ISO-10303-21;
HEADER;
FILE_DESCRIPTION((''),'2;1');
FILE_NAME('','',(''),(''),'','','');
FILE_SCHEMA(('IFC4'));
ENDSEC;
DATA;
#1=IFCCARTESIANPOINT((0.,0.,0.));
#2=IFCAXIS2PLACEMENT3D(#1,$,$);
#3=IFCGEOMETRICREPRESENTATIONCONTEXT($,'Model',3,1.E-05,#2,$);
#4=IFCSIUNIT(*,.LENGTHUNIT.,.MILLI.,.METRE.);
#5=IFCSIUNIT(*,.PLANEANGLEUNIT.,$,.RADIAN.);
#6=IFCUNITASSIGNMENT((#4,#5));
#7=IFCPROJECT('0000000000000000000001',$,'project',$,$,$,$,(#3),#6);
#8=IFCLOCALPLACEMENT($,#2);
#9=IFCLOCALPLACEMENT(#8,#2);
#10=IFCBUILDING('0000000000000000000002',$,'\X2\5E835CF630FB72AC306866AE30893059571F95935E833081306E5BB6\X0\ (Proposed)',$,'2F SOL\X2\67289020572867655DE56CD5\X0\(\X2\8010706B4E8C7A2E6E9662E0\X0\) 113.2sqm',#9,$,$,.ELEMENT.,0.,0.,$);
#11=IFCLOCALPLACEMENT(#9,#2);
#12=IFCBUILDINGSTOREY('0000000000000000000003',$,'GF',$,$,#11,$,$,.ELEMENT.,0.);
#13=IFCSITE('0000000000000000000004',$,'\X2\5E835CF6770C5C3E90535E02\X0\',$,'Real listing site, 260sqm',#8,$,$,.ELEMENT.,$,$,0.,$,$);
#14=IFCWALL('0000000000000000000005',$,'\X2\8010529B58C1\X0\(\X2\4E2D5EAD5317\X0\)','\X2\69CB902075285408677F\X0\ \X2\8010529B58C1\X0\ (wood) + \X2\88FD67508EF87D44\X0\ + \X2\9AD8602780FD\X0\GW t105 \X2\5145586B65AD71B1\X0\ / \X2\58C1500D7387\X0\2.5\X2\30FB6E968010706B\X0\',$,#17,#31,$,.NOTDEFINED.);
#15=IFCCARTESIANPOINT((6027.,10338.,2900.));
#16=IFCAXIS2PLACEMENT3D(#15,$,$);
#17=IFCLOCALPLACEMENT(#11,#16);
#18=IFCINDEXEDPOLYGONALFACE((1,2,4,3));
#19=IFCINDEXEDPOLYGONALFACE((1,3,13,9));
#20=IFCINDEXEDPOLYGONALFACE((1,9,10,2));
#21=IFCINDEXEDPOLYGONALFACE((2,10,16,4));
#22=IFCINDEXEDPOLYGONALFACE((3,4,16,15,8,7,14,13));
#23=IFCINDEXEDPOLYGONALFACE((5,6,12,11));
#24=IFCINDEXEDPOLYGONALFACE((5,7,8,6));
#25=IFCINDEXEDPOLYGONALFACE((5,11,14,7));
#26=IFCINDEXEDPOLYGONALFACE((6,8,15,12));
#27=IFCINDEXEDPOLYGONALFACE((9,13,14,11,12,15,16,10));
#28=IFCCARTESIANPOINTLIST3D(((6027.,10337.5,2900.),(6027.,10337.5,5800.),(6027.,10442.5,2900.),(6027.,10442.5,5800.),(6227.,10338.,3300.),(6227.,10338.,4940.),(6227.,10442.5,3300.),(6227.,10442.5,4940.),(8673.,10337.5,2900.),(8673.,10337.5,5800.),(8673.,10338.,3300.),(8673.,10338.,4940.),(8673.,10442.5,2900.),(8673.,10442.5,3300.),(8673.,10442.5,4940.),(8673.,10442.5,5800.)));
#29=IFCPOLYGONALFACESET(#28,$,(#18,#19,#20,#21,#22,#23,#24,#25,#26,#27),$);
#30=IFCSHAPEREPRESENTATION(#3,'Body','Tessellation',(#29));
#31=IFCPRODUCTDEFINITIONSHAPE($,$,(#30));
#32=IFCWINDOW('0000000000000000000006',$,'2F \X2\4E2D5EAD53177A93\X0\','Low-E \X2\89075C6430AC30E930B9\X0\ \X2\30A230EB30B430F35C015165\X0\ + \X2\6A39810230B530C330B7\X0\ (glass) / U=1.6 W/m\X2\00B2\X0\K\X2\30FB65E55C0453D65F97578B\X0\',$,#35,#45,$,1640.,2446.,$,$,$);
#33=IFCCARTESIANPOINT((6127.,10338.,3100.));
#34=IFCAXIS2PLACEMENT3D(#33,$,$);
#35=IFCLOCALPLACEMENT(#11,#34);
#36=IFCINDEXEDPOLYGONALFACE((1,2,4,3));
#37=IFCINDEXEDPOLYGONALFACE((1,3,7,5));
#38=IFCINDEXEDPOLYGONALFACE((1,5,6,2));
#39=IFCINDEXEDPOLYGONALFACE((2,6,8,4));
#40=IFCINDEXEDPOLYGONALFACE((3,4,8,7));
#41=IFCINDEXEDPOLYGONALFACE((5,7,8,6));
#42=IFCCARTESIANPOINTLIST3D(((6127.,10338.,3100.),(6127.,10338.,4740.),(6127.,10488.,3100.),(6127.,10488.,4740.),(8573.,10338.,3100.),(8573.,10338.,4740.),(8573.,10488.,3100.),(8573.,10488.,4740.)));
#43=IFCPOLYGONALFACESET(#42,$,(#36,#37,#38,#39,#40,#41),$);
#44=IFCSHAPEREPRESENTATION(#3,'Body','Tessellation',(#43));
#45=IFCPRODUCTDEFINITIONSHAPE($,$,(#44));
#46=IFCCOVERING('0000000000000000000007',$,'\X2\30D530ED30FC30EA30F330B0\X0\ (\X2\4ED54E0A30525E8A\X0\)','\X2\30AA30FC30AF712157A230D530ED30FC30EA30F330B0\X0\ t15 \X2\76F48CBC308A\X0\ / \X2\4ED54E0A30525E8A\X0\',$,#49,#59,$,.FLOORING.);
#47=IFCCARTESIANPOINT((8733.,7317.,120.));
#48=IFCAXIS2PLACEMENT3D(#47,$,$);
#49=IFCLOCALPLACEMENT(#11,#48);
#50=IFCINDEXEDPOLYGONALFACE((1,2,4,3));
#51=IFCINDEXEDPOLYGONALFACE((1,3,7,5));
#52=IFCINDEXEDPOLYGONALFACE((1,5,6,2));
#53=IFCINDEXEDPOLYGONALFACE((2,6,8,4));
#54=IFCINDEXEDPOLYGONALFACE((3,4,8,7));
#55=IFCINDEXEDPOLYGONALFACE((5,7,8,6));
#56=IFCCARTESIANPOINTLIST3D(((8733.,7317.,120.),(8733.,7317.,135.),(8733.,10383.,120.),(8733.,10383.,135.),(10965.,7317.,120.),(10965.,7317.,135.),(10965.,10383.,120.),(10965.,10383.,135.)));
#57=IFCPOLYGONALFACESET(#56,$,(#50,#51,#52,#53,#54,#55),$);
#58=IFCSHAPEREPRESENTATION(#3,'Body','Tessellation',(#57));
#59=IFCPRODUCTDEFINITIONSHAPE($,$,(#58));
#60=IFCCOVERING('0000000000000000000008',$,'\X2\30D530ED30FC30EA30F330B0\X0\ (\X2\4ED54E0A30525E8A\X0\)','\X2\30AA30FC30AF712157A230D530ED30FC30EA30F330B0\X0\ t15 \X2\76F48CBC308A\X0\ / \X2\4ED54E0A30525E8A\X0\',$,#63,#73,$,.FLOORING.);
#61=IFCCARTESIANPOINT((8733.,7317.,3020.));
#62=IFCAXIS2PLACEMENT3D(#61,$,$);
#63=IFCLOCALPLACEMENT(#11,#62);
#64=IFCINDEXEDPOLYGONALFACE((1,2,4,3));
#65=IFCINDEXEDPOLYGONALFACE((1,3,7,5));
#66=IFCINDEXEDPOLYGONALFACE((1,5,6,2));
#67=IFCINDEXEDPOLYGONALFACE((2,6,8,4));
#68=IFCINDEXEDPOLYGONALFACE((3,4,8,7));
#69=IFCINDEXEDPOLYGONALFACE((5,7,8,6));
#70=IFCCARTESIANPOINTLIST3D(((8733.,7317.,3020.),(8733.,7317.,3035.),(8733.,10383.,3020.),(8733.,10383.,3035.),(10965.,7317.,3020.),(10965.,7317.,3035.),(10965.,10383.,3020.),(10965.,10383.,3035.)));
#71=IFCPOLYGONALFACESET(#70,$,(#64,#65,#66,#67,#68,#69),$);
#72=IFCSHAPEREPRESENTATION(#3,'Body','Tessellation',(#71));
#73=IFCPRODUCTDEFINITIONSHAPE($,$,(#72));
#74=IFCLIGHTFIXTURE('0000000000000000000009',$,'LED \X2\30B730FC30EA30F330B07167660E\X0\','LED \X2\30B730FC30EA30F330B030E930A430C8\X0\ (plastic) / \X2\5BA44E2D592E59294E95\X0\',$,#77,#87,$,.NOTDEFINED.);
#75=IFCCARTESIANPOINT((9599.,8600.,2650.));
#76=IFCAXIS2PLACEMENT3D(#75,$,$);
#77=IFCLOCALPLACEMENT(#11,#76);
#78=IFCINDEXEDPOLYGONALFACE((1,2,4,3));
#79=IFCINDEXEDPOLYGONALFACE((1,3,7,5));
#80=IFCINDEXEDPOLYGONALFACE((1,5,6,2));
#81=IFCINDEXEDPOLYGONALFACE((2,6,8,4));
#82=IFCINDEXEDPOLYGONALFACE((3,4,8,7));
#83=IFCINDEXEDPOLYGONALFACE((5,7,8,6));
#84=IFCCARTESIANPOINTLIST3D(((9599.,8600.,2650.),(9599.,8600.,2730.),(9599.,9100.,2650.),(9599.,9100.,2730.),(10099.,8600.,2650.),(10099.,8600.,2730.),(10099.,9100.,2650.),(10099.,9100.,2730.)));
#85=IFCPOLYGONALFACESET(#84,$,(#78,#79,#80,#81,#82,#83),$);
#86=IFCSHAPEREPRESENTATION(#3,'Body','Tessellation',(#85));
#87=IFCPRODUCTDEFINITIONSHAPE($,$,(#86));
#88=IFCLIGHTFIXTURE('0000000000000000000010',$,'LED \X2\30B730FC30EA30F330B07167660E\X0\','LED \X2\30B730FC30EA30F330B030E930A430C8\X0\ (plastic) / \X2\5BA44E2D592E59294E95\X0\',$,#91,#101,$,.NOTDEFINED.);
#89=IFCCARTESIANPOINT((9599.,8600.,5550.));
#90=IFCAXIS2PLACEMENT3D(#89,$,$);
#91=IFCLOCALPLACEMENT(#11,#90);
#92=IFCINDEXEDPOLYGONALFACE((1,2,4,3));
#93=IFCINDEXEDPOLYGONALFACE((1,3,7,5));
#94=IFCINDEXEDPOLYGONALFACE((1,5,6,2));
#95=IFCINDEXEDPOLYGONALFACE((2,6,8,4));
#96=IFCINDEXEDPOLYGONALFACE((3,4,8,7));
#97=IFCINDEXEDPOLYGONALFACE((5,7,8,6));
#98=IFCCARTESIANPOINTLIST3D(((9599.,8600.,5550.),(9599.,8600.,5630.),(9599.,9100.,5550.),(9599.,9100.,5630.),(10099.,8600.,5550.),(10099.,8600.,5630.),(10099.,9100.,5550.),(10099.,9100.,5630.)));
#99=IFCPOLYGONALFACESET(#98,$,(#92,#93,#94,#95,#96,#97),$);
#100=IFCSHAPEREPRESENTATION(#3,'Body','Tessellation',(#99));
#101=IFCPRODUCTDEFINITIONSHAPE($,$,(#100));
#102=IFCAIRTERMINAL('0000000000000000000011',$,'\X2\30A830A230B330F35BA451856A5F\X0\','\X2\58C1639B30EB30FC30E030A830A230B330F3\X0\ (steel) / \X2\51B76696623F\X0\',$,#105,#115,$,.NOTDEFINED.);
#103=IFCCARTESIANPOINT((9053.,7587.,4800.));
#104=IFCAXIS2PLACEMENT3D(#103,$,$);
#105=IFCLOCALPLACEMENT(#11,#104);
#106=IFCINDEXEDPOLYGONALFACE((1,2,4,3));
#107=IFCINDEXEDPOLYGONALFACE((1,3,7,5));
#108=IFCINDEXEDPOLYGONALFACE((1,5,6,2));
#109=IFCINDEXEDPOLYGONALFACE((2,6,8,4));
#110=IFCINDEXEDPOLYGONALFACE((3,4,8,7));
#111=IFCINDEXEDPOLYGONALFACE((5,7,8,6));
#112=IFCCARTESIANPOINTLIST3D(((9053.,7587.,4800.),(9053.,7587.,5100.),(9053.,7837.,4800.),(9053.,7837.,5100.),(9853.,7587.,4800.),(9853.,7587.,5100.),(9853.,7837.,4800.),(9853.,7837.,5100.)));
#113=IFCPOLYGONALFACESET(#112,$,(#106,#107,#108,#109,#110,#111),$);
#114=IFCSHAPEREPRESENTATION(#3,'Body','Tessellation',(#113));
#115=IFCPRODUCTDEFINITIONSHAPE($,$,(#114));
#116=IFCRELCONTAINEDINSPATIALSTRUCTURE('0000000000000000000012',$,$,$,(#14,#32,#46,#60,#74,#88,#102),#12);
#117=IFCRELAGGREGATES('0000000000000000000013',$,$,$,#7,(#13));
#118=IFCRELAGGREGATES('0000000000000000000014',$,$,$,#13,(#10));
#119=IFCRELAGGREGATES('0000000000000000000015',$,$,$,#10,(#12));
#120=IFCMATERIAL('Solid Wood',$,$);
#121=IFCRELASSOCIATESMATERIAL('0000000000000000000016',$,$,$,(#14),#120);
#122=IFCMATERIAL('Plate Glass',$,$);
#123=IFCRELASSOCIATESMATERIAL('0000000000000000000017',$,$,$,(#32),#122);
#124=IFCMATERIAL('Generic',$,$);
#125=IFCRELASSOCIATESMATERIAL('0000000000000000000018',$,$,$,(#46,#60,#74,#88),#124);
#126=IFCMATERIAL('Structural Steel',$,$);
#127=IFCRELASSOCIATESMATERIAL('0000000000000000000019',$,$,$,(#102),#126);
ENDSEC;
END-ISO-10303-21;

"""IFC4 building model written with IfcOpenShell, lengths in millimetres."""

from ifc_helpers import new_model, si_unit, frame, frame_2d, origin, place, context, project, spatial, rectangle, extrude, material, element, fill, save


model = new_model("IFC4")

# Units and contexts
model_context = context("Model", 3, precision=1e-05, world=origin())
ifc_project = project(units=[si_unit("LENGTHUNIT", "METRE", prefix="MILLI"), si_unit("PLANEANGLEUNIT", "RADIAN")], contexts=[model_context])

# Site, building, storey
site_placement = place(None, origin())
site = spatial("IfcSite", under=ifc_project, at=site_placement, Name="広島県尾道市", ObjectType="Real listing site, 260sqm", CompositionType="ELEMENT", RefElevation=0.0)
building_placement = place(site_placement, origin())
building = spatial("IfcBuilding", under=site, at=building_placement, Name="広島・犬と暮らす土間広めの家 (Proposed)", ObjectType="2F SOL木造在来工法(耐火二種準拠) 113.2sqm", CompositionType="ELEMENT", ElevationOfRefHeight=0.0, ElevationOfTerrain=0.0)
storey_placement = place(building_placement, origin())
storey = spatial("IfcBuildingStorey", under=building, at=storey_placement, Name="GF", CompositionType="ELEMENT", Elevation=0.0)

# Shared definitions
ifc_material_1 = material(Name="Solid Wood")

# Wall, opening, window
ifc_material_2 = material(Name="Plate Glass")
wall_1_placement = place(storey_placement, frame((6027.0, 10338.0, 2900.0)))
wall_1 = element("IfcWall", 1, at=wall_1_placement, inside=storey, material=ifc_material_1, Name="耐力壁(中庭北)", Description="構造用合板 耐力壁 (wood) + 製材軸組 + 高性能GW t105 充填断熱 / 壁倍率2.5・準耐火", PredefinedType="NOTDEFINED", context=model_context, shape_type="SweptSolid", body=[
    extrude(rectangle(XDim=2646.0, YDim=105.0, at=frame_2d((1323.0, 52.0))), frame((6027.0, 10338.0, 2900.0)), (0.0, 0.0, 1.0), 2900.0),
])
opening_1_placement = place(storey_placement, frame((6127.0, 10338.0, 3100.0)))
opening_1 = element("IfcOpeningElement", 2, at=opening_1_placement, cuts=wall_1, PredefinedType="NOTDEFINED", context=model_context, shape_type="SweptSolid", body=[
    extrude(rectangle(XDim=2446.0, YDim=150.0, at=frame_2d((1223.0, 75.0))), frame((6127.0, 10338.0, 3100.0)), (0.0, 0.0, 1.0), 1640.0),
])
window_1_placement = place(storey_placement, frame((6127.0, 10338.0, 3100.0)))
window_1 = element("IfcWindow", 3, at=window_1_placement, inside=storey, material=ifc_material_2, Name="2F 中庭北窓", Description="Low-E 複層ガラス アルゴン封入 + 樹脂サッシ (glass) / U=1.6 W/m²K・日射取得型", OverallHeight=1640.0, OverallWidth=2446.0, context=model_context, shape_type="SweptSolid", body=[
    extrude(rectangle(XDim=2446.0, YDim=150.0, at=frame_2d((1223.0, 75.0))), frame((6127.0, 10338.0, 3100.0)), (0.0, 0.0, 1.0), 1640.0),
])
fill(opening_1, window_1)

# Coverings
ifc_material_3 = material(Name="Generic")
covering_1_placement = place(storey_placement, frame((8733.0, 7317.0, 120.0)))
element("IfcCovering", 4, at=covering_1_placement, inside=storey, material=ifc_material_3, Name="フローリング (仕上げ床)", Description="オーク無垢フローリング t15 直貼り / 仕上げ床", PredefinedType="FLOORING", context=model_context, shape_type="SweptSolid", body=[
    extrude(rectangle(XDim=2232.0, YDim=3066.0, at=frame_2d((1116.0, 1533.0))), frame((8733.0, 7317.0, 120.0)), (0.0, 0.0, 1.0), 15.0),
])
covering_2_placement = place(storey_placement, frame((8733.0, 7317.0, 3020.0)))
element("IfcCovering", 5, at=covering_2_placement, inside=storey, material=ifc_material_3, Name="フローリング (仕上げ床)", Description="オーク無垢フローリング t15 直貼り / 仕上げ床", PredefinedType="FLOORING", context=model_context, shape_type="SweptSolid", body=[
    extrude(rectangle(XDim=2232.0, YDim=3066.0, at=frame_2d((1116.0, 1533.0))), frame((8733.0, 7317.0, 3020.0)), (0.0, 0.0, 1.0), 15.0),
])

# Light fixtures
light_fixture_1_placement = place(storey_placement, frame((9599.0, 8600.0, 2650.0)))
element("IfcLightFixture", 6, at=light_fixture_1_placement, inside=storey, material=ifc_material_3, Name="LED シーリング照明", Description="LED シーリングライト (plastic) / 室中央天井", PredefinedType="NOTDEFINED", context=model_context, shape_type="SweptSolid", body=[
    extrude(rectangle(XDim=500.0, YDim=500.0, at=frame_2d((250.0, 250.0))), frame((9599.0, 8600.0, 2650.0)), (0.0, 0.0, 1.0), 80.0),
])
light_fixture_2_placement = place(storey_placement, frame((9599.0, 8600.0, 5550.0)))
element("IfcLightFixture", 7, at=light_fixture_2_placement, inside=storey, material=ifc_material_3, Name="LED シーリング照明", Description="LED シーリングライト (plastic) / 室中央天井", PredefinedType="NOTDEFINED", context=model_context, shape_type="SweptSolid", body=[
    extrude(rectangle(XDim=500.0, YDim=500.0, at=frame_2d((250.0, 250.0))), frame((9599.0, 8600.0, 5550.0)), (0.0, 0.0, 1.0), 80.0),
])

# Air terminal
ifc_material_4 = material(Name="Structural Steel")
air_terminal_placement = place(storey_placement, frame((9053.0, 7587.0, 4800.0)))
element("IfcAirTerminal", 8, at=air_terminal_placement, inside=storey, material=ifc_material_4, Name="エアコン室内機", Description="壁掛ルームエアコン (steel) / 冷暖房", PredefinedType="NOTDEFINED", context=model_context, shape_type="SweptSolid", body=[
    extrude(rectangle(XDim=800.0, YDim=250.0, at=frame_2d((400.0, 125.0))), frame((9053.0, 7587.0, 4800.0)), (0.0, 0.0, 1.0), 300.0),
])

save(model, "model.ifc")
